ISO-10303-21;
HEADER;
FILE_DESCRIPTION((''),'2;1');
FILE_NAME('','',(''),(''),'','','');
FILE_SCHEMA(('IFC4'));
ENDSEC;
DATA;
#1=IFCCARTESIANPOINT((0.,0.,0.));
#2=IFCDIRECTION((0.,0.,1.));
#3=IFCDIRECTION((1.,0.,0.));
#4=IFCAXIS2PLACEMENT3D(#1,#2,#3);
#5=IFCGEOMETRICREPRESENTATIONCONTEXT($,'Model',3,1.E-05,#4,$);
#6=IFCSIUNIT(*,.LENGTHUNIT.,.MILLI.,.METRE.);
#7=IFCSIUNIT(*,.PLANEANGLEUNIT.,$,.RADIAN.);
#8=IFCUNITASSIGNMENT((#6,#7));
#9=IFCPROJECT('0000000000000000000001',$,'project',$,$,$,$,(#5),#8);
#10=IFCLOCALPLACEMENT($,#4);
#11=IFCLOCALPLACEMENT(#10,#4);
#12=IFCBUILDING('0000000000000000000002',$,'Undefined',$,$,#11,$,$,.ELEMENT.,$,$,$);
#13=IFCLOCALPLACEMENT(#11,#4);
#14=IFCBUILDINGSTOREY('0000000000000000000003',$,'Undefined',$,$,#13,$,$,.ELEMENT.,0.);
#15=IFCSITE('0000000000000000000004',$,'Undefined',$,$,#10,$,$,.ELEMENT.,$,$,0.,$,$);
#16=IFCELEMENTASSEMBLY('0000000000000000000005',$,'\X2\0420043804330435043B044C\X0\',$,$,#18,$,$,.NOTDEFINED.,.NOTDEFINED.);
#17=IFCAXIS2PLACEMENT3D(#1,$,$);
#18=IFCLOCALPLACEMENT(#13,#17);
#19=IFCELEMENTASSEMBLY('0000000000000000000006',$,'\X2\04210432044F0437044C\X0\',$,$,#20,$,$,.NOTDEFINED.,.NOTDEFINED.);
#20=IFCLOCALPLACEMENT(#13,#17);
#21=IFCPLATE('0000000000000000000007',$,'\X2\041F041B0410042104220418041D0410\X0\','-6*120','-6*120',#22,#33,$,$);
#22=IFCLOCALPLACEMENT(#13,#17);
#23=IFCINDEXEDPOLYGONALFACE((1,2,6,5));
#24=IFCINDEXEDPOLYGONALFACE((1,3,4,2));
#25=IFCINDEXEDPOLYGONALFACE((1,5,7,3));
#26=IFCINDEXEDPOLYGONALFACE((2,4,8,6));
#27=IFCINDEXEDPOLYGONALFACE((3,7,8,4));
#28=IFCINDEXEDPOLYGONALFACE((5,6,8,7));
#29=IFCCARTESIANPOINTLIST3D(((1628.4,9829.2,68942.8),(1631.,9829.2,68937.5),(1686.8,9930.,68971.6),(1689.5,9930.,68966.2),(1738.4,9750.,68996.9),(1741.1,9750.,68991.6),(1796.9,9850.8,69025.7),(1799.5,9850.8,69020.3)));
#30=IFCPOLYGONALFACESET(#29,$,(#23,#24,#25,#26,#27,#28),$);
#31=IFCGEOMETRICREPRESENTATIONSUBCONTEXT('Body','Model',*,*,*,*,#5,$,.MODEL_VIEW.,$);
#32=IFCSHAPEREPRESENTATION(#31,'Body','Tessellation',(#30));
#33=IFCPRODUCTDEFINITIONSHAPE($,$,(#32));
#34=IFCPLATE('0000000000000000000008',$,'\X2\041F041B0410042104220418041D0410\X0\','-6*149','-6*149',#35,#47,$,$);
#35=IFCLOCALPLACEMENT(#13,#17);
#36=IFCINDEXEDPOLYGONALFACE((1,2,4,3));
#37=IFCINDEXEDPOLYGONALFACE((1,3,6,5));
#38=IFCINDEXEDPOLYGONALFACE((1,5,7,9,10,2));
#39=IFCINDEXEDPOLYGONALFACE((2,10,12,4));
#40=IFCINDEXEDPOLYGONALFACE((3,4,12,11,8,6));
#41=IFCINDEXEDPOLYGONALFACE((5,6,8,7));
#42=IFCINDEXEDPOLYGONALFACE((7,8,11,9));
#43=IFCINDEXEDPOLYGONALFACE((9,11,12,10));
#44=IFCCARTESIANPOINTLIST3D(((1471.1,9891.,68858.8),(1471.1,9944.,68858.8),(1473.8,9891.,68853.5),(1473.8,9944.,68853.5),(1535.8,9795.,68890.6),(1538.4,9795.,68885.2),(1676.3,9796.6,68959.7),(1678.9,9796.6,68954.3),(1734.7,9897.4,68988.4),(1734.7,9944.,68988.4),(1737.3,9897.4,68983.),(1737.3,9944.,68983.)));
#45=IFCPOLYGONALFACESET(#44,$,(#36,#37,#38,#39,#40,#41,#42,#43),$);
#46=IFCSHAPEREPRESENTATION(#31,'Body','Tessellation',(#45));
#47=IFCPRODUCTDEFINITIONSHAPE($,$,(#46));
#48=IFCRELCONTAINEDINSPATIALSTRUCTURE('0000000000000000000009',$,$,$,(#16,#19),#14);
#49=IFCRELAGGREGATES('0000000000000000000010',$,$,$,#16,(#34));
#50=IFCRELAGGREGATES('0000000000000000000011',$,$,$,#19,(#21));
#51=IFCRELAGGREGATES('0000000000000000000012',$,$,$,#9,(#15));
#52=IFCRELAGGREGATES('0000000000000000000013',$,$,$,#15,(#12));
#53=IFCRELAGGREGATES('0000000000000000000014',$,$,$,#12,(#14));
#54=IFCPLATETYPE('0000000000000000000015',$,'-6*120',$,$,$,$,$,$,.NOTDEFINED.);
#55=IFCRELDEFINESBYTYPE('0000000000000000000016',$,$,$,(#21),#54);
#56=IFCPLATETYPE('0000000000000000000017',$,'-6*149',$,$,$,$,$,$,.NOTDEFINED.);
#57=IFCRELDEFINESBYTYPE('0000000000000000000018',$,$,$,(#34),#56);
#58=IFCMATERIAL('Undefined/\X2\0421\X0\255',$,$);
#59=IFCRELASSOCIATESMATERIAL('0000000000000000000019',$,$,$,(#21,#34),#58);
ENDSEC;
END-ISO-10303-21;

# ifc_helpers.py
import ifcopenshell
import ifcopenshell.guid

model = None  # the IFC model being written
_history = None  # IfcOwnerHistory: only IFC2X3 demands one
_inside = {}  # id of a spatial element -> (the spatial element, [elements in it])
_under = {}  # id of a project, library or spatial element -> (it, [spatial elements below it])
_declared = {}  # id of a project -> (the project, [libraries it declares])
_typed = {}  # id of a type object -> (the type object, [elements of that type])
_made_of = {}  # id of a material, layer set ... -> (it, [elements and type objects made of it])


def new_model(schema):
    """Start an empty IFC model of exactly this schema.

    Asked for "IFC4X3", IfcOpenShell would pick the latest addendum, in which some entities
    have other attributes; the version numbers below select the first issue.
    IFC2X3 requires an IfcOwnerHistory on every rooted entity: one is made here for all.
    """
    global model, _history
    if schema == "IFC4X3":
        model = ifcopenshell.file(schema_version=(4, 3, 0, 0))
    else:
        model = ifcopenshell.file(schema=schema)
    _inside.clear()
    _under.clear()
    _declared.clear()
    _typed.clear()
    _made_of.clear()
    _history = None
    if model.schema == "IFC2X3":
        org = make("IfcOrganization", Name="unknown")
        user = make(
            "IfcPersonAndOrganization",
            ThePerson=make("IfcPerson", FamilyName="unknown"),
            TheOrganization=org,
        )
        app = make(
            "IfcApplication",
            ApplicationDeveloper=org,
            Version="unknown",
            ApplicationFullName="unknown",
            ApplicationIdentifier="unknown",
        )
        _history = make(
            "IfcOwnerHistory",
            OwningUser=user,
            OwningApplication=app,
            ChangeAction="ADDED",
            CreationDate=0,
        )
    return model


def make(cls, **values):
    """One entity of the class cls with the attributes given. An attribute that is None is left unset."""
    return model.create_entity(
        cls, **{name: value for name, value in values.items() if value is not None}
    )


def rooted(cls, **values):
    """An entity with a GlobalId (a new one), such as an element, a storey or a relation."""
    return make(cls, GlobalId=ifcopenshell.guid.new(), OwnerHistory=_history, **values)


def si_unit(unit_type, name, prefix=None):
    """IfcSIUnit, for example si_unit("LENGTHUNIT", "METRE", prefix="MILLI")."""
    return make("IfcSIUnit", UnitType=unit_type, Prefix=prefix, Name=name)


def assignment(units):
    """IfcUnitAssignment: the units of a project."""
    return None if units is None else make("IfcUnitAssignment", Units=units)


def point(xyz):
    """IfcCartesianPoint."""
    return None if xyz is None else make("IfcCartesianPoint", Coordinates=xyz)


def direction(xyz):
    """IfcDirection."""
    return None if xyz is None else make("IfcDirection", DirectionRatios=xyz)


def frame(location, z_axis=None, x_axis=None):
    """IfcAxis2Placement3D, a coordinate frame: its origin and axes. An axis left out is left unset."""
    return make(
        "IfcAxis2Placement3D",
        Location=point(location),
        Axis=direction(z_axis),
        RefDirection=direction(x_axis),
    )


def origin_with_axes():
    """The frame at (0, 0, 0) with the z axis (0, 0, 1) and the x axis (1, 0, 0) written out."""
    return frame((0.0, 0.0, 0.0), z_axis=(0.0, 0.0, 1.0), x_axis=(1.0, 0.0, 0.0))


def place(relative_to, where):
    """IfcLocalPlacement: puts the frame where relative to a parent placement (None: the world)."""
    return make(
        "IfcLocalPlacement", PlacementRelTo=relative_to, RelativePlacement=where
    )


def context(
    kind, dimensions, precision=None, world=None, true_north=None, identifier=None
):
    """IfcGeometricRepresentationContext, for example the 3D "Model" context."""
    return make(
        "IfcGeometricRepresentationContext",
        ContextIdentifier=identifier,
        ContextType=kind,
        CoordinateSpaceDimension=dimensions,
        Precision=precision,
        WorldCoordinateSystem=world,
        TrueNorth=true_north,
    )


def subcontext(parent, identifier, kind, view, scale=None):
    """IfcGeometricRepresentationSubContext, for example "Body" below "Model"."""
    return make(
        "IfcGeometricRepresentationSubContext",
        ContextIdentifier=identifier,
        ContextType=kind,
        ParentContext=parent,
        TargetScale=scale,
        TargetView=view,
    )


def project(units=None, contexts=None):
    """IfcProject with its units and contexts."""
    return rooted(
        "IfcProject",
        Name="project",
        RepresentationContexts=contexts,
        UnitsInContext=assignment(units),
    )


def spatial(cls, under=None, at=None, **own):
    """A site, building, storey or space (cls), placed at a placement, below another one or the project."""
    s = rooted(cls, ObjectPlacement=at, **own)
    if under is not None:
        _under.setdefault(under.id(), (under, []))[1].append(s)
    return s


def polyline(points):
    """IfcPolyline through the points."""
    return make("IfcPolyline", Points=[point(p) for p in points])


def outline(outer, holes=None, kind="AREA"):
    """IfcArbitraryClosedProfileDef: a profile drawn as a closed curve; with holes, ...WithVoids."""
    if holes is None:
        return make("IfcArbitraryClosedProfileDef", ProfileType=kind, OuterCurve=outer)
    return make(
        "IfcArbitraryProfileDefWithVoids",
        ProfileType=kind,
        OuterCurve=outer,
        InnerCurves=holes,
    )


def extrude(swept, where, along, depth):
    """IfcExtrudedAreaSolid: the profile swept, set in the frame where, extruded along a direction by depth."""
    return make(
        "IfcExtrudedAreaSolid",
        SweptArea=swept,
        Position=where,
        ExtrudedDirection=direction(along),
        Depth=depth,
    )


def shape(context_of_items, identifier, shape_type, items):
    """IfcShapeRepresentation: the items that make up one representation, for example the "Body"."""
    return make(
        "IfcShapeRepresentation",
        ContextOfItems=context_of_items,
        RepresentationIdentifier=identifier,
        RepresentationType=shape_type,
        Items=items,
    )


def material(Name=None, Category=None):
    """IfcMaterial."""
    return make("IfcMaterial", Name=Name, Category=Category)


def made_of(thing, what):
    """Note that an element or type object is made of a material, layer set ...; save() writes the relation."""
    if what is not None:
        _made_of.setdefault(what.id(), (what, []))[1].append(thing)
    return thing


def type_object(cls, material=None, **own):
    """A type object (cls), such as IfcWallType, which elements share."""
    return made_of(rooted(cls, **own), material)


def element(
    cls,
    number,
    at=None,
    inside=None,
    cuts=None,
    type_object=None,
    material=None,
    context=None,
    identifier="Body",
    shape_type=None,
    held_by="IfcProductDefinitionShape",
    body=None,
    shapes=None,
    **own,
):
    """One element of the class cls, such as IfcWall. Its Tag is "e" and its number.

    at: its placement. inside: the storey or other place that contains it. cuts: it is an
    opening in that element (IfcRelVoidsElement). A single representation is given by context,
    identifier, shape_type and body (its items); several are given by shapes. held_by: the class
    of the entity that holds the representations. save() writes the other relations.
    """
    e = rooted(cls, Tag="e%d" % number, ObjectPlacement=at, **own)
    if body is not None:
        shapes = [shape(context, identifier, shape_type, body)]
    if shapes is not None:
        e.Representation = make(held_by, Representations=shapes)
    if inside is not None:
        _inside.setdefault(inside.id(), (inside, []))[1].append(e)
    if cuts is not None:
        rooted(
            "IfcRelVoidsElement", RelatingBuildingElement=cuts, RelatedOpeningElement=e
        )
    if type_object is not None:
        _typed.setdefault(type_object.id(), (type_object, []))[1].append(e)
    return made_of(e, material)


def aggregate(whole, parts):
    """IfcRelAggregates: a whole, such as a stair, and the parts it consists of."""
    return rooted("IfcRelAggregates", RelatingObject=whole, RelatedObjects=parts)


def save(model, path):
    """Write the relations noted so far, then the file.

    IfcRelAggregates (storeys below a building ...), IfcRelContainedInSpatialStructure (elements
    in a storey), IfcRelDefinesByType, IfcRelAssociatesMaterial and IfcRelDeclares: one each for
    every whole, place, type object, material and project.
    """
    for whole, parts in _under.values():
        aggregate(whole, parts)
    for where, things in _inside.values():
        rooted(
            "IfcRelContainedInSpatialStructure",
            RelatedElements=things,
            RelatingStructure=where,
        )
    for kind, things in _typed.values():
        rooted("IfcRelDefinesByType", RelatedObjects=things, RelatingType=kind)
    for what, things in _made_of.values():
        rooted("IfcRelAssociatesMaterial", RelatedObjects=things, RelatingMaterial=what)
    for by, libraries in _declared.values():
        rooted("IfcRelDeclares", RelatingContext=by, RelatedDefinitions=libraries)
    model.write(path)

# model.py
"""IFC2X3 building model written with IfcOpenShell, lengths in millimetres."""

from ifc_helpers import new_model, si_unit, frame, origin_with_axes, place, context, subcontext, project, spatial, polyline, outline, extrude, material, type_object, element, aggregate, save


model = new_model("IFC2X3")

# Units and contexts
model_context = context("Model", 3, precision=1e-05, world=origin_with_axes())
body_context = subcontext(model_context, "Body", "Model", "MODEL_VIEW")
ifc_project = project(units=[si_unit("LENGTHUNIT", "METRE", prefix="MILLI"), si_unit("PLANEANGLEUNIT", "RADIAN")], contexts=[model_context])

# Site, building, storey
site_placement = place(None, origin_with_axes())
site = spatial("IfcSite", under=ifc_project, at=site_placement, Name="Undefined", CompositionType="ELEMENT", RefElevation=0.0)
building_placement = place(site_placement, origin_with_axes())
building = spatial("IfcBuilding", under=site, at=building_placement, Name="Undefined", CompositionType="ELEMENT")
storey_placement = place(building_placement, origin_with_axes())
storey = spatial("IfcBuildingStorey", under=building, at=storey_placement, Name="Undefined", CompositionType="ELEMENT", Elevation=0.0)

# Element assembly
assembly_1_placement = place(storey_placement, origin_with_axes())
assembly_1 = element("IfcElementAssembly", 1, at=assembly_1_placement, inside=storey, Name="Ригель", AssemblyPlace="NOTDEFINED", PredefinedType="NOTDEFINED")
ifc_material_1 = material(Name="Undefined/С255")

# Element assembly, plate
assembly_2_placement = place(storey_placement, origin_with_axes())
assembly_2 = element("IfcElementAssembly", 2, at=assembly_2_placement, inside=storey, Name="Связь", AssemblyPlace="NOTDEFINED", PredefinedType="NOTDEFINED")
plate_type_1 = type_object("IfcPlateType", Name="-6*120", PredefinedType="NOTDEFINED")
plate_1_placement = place(assembly_2_placement, frame((1688.2, 9930.0, 68968.9), z_axis=(-0.441222, -0.000001, 0.897398), x_axis=(-0.48707, -0.839889, -0.239478)))
plate_1 = element("IfcPlate", 3, at=plate_1_placement, type_object=plate_type_1, material=ifc_material_1, Name="ПЛАСТИНА", Description="-6*120", ObjectType="-6*120", context=body_context, shape_type="SweptSolid", body=[
    extrude(outline(polyline([(0.0, 0.0), (120.0, 0.0), (120.0, 146.0), (0.0, 146.0), (0.0, 0.0)])), frame((0.0, 0.0, -3.0), z_axis=(0.0, 0.0, 1.0), x_axis=(1.0, 0.0, 0.0)), (0.0, 0.0, 1.0), 6.0),
])

# Plate
plate_type_2 = type_object("IfcPlateType", Name="-6*149", PredefinedType="NOTDEFINED")
plate_2_placement = place(assembly_1_placement, frame((1736.0, 9944.0, 68985.7), z_axis=(-0.441224, 0.0, 0.897397), x_axis=(-0.897397, 0.0, -0.441224)))
plate_2 = element("IfcPlate", 4, at=plate_2_placement, type_object=plate_type_2, material=ifc_material_1, Name="ПЛАСТИНА", Description="-6*149", ObjectType="-6*149", context=body_context, shape_type="SweptSolid", body=[
    extrude(outline(polyline([(0.0, 0.0), (293.7, 0.0), (293.7, 53.0), (221.7, 149.0), (65.1, 147.4), (0.0, 46.6), (0.0, 0.0)])), frame((0.0, 0.0, -3.0), z_axis=(0.0, 0.0, 1.0), x_axis=(1.0, 0.0, 0.0)), (0.0, 0.0, 1.0), 6.0),
])

aggregate(assembly_1, [plate_2])
aggregate(assembly_2, [plate_1])

save(model, "model.ifc")
